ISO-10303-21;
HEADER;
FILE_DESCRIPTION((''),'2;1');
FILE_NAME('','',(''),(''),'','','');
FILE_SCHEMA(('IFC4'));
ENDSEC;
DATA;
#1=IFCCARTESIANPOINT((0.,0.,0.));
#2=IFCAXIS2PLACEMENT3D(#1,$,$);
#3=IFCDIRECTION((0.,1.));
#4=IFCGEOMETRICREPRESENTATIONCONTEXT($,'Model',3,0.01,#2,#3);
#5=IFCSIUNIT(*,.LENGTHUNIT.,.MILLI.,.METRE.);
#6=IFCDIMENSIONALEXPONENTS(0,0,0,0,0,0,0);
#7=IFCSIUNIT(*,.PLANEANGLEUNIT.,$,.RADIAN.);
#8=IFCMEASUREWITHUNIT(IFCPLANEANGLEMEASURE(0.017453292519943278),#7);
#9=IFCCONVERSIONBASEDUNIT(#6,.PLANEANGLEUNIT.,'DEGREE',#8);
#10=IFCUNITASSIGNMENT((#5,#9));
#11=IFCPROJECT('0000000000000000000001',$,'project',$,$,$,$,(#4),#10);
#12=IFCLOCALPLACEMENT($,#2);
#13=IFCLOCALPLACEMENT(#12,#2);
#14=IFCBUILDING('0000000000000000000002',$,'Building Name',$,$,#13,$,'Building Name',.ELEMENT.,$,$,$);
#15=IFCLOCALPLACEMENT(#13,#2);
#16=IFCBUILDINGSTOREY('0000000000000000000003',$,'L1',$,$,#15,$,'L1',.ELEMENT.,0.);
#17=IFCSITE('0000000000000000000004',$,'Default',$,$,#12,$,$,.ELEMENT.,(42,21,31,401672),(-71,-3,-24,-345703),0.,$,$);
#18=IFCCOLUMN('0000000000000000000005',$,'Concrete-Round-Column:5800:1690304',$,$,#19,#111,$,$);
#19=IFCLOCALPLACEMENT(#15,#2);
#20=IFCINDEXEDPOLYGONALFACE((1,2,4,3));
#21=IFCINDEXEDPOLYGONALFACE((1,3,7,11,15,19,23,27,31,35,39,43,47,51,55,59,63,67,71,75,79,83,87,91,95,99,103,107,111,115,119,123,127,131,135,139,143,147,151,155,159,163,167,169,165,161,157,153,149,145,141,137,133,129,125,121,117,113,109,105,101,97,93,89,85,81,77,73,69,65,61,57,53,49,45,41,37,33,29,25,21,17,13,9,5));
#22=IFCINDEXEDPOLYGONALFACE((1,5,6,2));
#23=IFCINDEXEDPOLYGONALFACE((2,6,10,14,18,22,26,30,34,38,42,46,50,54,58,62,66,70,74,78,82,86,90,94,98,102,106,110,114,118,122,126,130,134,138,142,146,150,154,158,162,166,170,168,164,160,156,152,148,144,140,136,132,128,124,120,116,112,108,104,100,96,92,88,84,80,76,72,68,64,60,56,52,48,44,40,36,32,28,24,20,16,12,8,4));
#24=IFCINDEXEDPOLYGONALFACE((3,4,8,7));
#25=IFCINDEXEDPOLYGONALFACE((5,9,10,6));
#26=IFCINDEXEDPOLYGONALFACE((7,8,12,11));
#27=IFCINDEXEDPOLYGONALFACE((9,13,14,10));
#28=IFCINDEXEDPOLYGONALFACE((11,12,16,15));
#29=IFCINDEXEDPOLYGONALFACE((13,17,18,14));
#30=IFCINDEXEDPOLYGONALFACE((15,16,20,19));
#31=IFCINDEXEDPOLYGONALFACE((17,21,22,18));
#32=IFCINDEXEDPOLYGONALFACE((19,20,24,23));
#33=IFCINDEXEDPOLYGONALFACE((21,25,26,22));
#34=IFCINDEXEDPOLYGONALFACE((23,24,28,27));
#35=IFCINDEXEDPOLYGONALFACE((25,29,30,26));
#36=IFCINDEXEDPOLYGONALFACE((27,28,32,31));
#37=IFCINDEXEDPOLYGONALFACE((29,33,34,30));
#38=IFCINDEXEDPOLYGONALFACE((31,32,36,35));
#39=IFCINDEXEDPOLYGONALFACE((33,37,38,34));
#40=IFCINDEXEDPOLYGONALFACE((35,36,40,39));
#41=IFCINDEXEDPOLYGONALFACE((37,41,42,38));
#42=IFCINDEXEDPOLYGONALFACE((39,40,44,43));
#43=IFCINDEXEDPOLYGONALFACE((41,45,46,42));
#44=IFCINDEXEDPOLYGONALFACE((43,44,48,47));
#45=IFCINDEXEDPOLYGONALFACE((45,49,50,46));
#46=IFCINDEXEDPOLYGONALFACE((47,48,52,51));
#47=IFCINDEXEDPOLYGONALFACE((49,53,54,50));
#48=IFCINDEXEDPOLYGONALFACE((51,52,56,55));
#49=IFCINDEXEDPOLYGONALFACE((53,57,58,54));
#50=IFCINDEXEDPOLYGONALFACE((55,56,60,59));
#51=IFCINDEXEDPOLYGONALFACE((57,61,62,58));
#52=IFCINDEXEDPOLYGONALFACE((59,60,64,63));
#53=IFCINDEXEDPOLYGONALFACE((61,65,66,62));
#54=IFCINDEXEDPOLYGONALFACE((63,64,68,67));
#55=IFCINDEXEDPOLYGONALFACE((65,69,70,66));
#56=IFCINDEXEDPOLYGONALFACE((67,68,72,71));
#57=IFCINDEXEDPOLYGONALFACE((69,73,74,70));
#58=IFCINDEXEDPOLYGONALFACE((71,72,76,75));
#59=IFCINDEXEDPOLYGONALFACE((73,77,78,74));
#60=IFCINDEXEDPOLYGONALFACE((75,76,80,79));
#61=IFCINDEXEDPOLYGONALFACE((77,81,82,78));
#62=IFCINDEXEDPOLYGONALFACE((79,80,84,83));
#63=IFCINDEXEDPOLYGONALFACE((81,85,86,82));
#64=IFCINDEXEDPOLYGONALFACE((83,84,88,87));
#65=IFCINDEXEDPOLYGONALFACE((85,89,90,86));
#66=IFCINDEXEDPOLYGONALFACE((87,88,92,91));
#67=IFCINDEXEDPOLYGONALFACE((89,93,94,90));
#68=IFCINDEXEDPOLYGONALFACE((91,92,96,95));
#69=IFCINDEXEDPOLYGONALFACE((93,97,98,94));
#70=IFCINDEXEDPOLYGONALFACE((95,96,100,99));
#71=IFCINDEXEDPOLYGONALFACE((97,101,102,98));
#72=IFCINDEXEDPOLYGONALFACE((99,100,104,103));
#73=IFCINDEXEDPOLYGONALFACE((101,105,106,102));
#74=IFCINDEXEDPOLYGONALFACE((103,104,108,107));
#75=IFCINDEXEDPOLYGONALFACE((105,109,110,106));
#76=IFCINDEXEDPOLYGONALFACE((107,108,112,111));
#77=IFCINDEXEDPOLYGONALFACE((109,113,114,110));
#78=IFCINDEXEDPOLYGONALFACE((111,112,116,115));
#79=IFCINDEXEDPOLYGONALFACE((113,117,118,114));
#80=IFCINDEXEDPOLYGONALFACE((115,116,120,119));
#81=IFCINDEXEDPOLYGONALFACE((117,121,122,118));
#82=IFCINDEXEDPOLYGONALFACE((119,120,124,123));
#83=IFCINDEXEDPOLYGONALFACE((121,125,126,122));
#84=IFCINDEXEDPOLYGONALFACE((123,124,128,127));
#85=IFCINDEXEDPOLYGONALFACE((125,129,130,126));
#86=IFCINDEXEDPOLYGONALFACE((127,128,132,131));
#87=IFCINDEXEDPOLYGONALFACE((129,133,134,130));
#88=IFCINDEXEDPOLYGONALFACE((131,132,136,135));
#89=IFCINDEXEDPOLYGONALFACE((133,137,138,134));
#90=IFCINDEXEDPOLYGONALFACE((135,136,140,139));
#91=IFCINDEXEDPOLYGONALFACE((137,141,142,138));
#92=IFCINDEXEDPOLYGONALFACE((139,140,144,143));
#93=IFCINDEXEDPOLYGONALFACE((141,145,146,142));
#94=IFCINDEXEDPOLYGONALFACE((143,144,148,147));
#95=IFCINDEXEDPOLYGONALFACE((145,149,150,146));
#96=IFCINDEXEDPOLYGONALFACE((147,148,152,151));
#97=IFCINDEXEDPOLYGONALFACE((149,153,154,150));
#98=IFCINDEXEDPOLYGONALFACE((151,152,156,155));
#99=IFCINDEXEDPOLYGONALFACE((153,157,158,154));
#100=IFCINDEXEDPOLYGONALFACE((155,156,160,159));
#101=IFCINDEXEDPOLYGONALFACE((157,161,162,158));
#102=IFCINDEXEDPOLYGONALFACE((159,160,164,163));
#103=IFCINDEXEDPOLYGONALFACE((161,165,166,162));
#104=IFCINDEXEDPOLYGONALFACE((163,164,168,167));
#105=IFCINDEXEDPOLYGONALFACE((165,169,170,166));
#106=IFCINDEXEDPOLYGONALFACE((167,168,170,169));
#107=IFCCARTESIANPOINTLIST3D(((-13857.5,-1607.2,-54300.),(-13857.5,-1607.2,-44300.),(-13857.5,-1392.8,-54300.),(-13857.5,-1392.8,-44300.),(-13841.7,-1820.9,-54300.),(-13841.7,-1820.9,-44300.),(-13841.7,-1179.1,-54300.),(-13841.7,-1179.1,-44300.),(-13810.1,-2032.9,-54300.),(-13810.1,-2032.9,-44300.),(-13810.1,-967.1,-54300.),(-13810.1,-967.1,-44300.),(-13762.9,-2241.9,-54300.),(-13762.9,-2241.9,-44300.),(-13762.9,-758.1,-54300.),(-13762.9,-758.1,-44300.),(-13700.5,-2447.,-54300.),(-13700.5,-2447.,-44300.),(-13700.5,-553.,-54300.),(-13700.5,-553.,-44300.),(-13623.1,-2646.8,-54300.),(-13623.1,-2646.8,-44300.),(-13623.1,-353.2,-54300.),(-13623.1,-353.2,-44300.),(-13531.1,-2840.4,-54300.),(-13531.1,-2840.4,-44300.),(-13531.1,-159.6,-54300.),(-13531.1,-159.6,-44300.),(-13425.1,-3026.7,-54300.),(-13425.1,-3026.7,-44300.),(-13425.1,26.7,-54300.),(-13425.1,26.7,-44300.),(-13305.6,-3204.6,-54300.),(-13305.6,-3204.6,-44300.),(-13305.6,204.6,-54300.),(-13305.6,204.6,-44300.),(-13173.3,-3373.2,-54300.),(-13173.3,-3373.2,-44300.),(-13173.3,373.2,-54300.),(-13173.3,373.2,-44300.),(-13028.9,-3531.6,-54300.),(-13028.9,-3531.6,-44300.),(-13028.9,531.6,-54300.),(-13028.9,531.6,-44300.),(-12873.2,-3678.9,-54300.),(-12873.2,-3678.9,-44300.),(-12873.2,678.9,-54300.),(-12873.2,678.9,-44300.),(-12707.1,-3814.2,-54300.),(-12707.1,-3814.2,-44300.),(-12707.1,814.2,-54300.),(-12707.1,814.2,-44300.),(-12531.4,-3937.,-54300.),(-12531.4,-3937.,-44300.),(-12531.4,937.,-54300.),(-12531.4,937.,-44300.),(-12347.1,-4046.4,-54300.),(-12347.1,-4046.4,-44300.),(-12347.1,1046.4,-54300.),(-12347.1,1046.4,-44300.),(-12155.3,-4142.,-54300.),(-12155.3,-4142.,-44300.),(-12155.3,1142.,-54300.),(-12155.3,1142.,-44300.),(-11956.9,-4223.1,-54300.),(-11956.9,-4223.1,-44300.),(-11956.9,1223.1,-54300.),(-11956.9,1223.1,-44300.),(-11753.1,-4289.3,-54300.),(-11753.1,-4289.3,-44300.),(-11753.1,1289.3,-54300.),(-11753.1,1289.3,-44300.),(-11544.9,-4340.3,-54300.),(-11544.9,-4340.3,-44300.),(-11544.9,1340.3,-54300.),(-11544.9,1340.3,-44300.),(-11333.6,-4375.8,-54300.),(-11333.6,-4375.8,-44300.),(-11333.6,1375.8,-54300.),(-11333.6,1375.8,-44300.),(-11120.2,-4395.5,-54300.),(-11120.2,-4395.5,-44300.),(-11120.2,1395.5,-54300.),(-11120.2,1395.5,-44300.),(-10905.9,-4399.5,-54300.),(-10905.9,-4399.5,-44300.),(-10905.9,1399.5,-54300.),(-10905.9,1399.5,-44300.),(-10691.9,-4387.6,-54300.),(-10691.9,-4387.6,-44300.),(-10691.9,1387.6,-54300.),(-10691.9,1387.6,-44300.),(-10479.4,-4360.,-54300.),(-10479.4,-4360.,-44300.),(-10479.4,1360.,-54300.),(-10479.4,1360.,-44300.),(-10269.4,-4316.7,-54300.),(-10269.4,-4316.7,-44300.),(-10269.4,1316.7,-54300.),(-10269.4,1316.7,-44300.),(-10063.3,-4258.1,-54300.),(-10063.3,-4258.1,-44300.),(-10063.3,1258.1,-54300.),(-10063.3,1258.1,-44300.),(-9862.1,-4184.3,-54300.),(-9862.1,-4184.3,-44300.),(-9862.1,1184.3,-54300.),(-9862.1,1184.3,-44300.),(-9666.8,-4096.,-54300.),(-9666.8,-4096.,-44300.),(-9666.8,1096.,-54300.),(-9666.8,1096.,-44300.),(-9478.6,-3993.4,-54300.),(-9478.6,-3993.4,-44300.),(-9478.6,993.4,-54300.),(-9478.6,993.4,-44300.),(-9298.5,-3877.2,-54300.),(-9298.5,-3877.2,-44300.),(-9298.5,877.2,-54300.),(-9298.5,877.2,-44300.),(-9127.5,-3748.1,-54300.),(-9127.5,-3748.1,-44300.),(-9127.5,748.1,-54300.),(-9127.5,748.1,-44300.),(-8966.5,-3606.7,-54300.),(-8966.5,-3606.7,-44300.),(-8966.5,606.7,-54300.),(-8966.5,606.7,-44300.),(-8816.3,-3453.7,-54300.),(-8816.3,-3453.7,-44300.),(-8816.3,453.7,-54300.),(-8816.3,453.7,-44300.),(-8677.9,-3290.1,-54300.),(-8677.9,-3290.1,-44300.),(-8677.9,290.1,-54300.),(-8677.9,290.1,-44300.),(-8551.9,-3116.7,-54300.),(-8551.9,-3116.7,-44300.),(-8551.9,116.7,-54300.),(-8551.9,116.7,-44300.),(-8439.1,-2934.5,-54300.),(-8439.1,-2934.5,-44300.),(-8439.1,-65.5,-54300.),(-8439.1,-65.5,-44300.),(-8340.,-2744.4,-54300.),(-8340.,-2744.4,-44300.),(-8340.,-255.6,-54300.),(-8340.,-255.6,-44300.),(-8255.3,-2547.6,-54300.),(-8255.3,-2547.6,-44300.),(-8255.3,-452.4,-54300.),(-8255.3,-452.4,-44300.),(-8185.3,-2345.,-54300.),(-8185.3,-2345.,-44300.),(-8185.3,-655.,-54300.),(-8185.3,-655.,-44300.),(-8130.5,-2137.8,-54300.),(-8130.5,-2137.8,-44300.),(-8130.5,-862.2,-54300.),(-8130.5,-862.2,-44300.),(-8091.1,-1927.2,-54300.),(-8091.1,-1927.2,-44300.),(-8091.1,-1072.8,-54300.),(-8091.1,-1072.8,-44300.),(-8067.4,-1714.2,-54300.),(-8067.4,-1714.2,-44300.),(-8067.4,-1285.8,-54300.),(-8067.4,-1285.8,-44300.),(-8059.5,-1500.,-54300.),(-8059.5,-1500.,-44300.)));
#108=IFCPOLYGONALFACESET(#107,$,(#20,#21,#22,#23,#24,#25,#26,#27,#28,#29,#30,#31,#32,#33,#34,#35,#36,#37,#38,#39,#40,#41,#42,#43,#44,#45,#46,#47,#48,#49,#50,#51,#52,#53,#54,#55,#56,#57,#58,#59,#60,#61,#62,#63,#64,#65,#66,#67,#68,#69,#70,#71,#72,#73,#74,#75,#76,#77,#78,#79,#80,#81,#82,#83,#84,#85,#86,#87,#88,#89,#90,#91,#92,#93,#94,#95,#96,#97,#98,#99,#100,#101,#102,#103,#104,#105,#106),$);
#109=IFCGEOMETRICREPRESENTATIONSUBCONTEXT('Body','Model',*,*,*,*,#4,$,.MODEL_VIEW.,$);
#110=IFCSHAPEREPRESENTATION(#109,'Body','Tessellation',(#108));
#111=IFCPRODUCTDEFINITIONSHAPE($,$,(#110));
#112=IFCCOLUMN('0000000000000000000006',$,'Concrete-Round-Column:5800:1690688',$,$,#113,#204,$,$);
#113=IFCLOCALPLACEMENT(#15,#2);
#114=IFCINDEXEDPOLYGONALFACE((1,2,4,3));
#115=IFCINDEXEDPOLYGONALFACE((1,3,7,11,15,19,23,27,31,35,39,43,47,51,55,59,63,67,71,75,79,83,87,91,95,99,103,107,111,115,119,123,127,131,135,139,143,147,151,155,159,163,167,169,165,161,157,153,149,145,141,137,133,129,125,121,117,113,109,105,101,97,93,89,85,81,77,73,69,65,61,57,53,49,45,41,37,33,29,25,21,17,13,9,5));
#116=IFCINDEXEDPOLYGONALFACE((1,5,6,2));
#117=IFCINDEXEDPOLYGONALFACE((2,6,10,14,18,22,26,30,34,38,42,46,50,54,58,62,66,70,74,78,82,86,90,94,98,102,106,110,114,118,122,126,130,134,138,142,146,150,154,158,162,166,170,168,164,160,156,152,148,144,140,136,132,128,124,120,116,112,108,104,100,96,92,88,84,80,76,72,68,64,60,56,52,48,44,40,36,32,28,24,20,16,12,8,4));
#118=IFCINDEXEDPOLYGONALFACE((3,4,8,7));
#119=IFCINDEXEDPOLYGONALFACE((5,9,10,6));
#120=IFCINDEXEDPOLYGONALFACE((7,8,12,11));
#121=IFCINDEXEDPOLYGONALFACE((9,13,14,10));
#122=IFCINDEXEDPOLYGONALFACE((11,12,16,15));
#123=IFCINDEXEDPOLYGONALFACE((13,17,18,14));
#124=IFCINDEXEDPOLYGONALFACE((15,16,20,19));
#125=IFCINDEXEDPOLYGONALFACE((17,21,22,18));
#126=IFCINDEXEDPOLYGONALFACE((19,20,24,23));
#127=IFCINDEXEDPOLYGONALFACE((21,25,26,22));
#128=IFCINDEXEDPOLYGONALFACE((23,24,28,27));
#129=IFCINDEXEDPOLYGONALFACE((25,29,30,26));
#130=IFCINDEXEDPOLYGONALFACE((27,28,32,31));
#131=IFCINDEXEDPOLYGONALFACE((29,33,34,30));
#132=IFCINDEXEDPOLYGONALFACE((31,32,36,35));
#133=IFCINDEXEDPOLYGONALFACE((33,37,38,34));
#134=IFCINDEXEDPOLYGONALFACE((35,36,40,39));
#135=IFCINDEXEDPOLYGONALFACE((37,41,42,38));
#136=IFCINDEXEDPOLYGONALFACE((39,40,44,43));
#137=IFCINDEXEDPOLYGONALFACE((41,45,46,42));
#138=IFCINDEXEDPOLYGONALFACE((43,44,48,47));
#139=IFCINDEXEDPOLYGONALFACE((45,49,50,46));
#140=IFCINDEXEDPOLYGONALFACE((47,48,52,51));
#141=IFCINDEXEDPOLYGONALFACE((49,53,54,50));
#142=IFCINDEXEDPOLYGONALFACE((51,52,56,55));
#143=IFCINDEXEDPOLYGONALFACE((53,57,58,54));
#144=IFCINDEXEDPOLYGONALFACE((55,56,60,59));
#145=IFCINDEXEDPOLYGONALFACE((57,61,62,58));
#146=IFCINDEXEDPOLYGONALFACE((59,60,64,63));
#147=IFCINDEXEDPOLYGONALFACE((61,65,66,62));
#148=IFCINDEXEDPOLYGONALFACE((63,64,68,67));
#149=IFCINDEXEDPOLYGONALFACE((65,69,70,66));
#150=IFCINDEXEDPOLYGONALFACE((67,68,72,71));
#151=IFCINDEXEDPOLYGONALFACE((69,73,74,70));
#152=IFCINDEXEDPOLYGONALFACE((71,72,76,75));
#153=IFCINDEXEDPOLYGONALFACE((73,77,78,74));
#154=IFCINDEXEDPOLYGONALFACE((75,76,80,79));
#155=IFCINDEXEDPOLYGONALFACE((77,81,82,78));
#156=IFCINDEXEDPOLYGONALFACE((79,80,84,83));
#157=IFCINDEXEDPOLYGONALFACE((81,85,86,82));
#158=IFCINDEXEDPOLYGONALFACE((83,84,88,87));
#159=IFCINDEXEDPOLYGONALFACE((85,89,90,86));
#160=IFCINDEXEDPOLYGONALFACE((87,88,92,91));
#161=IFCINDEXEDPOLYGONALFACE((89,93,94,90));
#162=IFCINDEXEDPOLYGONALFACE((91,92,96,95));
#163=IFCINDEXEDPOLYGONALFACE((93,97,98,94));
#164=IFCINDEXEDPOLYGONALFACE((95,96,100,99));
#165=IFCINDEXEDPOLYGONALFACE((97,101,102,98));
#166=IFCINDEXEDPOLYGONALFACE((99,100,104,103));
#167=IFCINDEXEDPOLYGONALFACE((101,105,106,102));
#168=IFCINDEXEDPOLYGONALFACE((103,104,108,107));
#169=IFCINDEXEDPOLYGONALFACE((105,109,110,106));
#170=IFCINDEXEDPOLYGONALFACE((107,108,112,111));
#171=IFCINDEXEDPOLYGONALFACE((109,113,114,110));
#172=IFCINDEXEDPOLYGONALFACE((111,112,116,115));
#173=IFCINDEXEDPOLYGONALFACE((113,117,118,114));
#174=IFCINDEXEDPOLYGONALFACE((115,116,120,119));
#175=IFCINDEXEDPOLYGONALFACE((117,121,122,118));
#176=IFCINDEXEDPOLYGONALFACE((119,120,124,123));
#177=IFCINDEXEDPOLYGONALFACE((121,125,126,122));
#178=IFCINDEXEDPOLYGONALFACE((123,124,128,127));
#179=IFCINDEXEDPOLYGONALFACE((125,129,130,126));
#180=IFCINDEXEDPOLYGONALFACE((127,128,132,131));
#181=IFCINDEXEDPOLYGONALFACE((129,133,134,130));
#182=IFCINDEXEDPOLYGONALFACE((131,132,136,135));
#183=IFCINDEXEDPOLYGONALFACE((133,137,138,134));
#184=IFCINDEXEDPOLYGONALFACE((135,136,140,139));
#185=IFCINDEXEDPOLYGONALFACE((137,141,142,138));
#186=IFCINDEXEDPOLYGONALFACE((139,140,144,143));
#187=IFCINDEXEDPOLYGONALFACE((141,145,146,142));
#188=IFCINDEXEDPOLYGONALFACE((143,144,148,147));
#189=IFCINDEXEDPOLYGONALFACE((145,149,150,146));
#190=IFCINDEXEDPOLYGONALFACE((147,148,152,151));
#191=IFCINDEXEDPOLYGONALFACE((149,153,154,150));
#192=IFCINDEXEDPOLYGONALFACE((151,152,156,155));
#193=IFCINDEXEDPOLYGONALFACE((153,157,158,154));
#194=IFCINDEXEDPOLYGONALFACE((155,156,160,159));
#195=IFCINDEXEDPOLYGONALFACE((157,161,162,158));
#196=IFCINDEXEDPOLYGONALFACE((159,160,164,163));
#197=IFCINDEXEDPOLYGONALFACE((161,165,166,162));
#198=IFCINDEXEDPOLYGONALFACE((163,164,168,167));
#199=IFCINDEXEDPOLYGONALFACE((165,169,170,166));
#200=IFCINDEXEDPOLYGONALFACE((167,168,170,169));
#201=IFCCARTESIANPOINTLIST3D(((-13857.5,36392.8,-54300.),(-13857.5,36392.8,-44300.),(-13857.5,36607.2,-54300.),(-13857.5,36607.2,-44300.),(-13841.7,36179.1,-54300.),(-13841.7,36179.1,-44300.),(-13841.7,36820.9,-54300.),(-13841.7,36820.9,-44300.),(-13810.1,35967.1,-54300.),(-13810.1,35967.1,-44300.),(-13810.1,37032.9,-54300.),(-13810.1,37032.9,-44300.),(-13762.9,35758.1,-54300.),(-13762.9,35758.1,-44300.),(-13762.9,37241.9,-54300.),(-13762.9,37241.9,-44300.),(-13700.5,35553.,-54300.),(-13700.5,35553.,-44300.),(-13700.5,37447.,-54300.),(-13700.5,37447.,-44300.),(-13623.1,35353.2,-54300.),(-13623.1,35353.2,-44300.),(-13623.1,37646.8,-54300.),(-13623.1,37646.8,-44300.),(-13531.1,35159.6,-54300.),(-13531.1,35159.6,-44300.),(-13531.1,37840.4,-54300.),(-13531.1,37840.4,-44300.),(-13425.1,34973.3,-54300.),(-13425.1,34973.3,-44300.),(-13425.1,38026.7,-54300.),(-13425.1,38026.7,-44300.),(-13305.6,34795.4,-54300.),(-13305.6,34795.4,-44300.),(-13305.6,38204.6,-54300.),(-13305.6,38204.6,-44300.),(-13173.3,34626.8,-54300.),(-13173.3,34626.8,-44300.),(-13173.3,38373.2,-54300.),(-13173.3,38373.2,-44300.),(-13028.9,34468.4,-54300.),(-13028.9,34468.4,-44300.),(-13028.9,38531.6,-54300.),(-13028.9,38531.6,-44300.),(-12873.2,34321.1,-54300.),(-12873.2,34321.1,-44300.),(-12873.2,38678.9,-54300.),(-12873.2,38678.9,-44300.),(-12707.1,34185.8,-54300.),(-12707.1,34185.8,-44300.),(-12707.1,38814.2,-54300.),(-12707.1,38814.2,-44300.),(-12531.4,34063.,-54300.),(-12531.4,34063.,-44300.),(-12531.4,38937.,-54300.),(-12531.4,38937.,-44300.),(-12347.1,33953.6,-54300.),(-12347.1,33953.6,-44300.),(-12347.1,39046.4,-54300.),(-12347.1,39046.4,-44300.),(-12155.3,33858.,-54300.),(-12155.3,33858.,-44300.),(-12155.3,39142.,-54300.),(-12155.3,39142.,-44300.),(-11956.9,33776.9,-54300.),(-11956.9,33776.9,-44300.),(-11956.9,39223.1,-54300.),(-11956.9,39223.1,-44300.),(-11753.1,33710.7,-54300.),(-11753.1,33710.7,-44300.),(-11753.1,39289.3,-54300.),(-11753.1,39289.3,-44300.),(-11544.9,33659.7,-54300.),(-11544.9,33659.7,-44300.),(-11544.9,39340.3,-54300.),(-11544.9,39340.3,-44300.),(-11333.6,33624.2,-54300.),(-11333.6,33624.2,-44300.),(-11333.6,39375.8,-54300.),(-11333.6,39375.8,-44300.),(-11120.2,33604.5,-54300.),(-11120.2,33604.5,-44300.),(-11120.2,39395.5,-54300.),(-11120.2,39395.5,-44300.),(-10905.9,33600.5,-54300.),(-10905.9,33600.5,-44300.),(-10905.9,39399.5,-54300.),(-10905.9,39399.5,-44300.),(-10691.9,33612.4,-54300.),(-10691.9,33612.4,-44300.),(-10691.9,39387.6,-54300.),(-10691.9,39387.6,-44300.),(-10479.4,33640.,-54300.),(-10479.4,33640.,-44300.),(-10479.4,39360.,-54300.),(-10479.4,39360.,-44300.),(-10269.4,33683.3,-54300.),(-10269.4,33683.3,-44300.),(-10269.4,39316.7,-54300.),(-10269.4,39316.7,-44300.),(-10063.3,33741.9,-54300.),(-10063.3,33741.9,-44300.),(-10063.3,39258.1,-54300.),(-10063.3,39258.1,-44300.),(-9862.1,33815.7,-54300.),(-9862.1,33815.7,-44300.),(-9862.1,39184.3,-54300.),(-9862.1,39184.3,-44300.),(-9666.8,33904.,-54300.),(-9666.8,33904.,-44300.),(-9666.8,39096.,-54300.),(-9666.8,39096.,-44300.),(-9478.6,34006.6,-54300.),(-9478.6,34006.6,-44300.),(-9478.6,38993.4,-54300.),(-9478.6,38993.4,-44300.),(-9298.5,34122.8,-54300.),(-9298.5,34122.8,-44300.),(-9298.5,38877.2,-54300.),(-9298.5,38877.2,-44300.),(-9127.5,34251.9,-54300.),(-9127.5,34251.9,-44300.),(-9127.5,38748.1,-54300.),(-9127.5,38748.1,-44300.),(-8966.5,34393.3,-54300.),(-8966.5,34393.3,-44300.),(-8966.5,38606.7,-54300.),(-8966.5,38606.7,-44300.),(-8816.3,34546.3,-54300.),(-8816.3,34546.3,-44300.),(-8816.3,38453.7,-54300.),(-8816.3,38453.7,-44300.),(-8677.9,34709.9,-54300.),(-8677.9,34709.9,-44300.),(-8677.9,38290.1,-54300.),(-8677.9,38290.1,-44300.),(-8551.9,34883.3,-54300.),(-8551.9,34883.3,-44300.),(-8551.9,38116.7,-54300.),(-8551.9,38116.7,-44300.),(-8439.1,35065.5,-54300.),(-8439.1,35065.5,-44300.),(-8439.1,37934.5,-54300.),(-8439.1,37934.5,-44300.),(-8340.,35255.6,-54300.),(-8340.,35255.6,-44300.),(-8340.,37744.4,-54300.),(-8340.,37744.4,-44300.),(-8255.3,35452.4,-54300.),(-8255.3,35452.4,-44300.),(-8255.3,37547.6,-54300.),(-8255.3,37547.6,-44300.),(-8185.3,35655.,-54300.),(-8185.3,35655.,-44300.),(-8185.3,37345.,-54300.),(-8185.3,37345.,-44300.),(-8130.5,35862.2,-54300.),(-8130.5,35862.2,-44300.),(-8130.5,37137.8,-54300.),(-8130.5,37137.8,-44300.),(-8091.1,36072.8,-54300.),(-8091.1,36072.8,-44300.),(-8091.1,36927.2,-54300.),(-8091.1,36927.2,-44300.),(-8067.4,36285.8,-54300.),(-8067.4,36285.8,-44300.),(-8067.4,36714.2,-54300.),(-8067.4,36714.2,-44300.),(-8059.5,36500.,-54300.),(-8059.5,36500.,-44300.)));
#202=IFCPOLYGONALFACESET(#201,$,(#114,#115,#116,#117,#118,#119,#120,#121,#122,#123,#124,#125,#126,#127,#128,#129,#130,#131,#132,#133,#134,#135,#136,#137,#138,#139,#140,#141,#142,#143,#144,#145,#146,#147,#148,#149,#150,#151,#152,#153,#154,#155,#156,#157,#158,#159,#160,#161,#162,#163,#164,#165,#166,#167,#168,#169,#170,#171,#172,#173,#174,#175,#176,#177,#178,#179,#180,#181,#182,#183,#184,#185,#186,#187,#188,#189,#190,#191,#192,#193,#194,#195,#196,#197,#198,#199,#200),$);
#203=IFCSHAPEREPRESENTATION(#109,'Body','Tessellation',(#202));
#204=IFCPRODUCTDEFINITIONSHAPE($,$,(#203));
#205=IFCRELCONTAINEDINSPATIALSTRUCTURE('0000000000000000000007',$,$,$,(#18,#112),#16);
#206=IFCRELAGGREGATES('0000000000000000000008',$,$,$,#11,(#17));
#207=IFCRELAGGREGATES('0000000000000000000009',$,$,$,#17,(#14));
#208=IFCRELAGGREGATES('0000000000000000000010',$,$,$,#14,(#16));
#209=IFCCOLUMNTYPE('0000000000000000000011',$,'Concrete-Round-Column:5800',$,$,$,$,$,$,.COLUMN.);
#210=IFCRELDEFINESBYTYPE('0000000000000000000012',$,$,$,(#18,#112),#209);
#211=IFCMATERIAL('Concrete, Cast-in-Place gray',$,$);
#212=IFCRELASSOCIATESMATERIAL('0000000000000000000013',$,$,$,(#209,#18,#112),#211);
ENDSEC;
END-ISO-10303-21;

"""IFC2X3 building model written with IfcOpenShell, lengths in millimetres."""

from ifc_helpers import new_model, entity, si_unit, converted_unit, direction, frame, frame_2d, origin, place, context, subcontext, project, spatial, circle, extrude, source, transform, mapped, material, type_object, type_shapes, element, save


model = new_model("IFC2X3")

# Units and contexts
model_context = context("Model", 3, precision=0.01, world=origin(), true_north=direction((0.0, 1.0)))
body_context = subcontext(model_context, "Body", "Model", "MODEL_VIEW")
ifc_project = project(units=[si_unit("LENGTHUNIT", "METRE", prefix="MILLI"), converted_unit("PLANEANGLEUNIT", "DEGREE", entity("IfcPlaneAngleMeasure", 0.017453292519943278), si_unit("PLANEANGLEUNIT", "RADIAN"), dimensions=[0, 0, 0, 0, 0, 0, 0])], contexts=[model_context])

# Site, building, storey
site_placement = place(None, origin())
site = spatial("IfcSite", under=ifc_project, at=site_placement, Name="Default", CompositionType="ELEMENT", RefLatitude=(42, 21, 31, 401672), RefLongitude=(-71, -3, -24, -345703), RefElevation=0.0)
building_placement = place(site_placement, origin())
building = spatial("IfcBuilding", under=site, at=building_placement, Name="Building Name", LongName="Building Name", CompositionType="ELEMENT")
storey_placement = place(building_placement, origin())
storey = spatial("IfcBuildingStorey", under=building, at=storey_placement, Name="L1", LongName="L1", CompositionType="ELEMENT", Elevation=0.0)

# Columns
ifc_material_1 = material(Name="Concrete, Cast-in-Place gray")
column_type_1 = type_object("IfcColumnType", Name="Concrete-Round-Column:5800", PredefinedType="COLUMN", material=ifc_material_1)
shared_shape_1 = source(origin(), body_context, "Body", "SweptSolid", [
    extrude(circle(Radius=2900.0, at=frame_2d((0.0, 0.0), x_axis=(1.0, 0.0))), frame((0.0, 0.0, -54300.0)), (0.0, 0.0, 1.0), 10000.0),
])
type_shapes(column_type_1, [shared_shape_1])
for number, where, name in (
    (1, (-10959.5, -1500.0, 0.0), "Concrete-Round-Column:5800:1690304"),
    (2, (-10959.5, 36500.0, 0.0), "Concrete-Round-Column:5800:1690688"),
):
    element("IfcColumn", number, at=place(storey_placement, frame(where)), inside=storey, type_object=column_type_1, material=ifc_material_1, Name=name, context=body_context, shape_type="MappedRepresentation", body=[
        mapped(shared_shape_1, transform((0.0, 0.0, 0.0), scale=1.0)),
    ])

save(model, "model.ifc")
